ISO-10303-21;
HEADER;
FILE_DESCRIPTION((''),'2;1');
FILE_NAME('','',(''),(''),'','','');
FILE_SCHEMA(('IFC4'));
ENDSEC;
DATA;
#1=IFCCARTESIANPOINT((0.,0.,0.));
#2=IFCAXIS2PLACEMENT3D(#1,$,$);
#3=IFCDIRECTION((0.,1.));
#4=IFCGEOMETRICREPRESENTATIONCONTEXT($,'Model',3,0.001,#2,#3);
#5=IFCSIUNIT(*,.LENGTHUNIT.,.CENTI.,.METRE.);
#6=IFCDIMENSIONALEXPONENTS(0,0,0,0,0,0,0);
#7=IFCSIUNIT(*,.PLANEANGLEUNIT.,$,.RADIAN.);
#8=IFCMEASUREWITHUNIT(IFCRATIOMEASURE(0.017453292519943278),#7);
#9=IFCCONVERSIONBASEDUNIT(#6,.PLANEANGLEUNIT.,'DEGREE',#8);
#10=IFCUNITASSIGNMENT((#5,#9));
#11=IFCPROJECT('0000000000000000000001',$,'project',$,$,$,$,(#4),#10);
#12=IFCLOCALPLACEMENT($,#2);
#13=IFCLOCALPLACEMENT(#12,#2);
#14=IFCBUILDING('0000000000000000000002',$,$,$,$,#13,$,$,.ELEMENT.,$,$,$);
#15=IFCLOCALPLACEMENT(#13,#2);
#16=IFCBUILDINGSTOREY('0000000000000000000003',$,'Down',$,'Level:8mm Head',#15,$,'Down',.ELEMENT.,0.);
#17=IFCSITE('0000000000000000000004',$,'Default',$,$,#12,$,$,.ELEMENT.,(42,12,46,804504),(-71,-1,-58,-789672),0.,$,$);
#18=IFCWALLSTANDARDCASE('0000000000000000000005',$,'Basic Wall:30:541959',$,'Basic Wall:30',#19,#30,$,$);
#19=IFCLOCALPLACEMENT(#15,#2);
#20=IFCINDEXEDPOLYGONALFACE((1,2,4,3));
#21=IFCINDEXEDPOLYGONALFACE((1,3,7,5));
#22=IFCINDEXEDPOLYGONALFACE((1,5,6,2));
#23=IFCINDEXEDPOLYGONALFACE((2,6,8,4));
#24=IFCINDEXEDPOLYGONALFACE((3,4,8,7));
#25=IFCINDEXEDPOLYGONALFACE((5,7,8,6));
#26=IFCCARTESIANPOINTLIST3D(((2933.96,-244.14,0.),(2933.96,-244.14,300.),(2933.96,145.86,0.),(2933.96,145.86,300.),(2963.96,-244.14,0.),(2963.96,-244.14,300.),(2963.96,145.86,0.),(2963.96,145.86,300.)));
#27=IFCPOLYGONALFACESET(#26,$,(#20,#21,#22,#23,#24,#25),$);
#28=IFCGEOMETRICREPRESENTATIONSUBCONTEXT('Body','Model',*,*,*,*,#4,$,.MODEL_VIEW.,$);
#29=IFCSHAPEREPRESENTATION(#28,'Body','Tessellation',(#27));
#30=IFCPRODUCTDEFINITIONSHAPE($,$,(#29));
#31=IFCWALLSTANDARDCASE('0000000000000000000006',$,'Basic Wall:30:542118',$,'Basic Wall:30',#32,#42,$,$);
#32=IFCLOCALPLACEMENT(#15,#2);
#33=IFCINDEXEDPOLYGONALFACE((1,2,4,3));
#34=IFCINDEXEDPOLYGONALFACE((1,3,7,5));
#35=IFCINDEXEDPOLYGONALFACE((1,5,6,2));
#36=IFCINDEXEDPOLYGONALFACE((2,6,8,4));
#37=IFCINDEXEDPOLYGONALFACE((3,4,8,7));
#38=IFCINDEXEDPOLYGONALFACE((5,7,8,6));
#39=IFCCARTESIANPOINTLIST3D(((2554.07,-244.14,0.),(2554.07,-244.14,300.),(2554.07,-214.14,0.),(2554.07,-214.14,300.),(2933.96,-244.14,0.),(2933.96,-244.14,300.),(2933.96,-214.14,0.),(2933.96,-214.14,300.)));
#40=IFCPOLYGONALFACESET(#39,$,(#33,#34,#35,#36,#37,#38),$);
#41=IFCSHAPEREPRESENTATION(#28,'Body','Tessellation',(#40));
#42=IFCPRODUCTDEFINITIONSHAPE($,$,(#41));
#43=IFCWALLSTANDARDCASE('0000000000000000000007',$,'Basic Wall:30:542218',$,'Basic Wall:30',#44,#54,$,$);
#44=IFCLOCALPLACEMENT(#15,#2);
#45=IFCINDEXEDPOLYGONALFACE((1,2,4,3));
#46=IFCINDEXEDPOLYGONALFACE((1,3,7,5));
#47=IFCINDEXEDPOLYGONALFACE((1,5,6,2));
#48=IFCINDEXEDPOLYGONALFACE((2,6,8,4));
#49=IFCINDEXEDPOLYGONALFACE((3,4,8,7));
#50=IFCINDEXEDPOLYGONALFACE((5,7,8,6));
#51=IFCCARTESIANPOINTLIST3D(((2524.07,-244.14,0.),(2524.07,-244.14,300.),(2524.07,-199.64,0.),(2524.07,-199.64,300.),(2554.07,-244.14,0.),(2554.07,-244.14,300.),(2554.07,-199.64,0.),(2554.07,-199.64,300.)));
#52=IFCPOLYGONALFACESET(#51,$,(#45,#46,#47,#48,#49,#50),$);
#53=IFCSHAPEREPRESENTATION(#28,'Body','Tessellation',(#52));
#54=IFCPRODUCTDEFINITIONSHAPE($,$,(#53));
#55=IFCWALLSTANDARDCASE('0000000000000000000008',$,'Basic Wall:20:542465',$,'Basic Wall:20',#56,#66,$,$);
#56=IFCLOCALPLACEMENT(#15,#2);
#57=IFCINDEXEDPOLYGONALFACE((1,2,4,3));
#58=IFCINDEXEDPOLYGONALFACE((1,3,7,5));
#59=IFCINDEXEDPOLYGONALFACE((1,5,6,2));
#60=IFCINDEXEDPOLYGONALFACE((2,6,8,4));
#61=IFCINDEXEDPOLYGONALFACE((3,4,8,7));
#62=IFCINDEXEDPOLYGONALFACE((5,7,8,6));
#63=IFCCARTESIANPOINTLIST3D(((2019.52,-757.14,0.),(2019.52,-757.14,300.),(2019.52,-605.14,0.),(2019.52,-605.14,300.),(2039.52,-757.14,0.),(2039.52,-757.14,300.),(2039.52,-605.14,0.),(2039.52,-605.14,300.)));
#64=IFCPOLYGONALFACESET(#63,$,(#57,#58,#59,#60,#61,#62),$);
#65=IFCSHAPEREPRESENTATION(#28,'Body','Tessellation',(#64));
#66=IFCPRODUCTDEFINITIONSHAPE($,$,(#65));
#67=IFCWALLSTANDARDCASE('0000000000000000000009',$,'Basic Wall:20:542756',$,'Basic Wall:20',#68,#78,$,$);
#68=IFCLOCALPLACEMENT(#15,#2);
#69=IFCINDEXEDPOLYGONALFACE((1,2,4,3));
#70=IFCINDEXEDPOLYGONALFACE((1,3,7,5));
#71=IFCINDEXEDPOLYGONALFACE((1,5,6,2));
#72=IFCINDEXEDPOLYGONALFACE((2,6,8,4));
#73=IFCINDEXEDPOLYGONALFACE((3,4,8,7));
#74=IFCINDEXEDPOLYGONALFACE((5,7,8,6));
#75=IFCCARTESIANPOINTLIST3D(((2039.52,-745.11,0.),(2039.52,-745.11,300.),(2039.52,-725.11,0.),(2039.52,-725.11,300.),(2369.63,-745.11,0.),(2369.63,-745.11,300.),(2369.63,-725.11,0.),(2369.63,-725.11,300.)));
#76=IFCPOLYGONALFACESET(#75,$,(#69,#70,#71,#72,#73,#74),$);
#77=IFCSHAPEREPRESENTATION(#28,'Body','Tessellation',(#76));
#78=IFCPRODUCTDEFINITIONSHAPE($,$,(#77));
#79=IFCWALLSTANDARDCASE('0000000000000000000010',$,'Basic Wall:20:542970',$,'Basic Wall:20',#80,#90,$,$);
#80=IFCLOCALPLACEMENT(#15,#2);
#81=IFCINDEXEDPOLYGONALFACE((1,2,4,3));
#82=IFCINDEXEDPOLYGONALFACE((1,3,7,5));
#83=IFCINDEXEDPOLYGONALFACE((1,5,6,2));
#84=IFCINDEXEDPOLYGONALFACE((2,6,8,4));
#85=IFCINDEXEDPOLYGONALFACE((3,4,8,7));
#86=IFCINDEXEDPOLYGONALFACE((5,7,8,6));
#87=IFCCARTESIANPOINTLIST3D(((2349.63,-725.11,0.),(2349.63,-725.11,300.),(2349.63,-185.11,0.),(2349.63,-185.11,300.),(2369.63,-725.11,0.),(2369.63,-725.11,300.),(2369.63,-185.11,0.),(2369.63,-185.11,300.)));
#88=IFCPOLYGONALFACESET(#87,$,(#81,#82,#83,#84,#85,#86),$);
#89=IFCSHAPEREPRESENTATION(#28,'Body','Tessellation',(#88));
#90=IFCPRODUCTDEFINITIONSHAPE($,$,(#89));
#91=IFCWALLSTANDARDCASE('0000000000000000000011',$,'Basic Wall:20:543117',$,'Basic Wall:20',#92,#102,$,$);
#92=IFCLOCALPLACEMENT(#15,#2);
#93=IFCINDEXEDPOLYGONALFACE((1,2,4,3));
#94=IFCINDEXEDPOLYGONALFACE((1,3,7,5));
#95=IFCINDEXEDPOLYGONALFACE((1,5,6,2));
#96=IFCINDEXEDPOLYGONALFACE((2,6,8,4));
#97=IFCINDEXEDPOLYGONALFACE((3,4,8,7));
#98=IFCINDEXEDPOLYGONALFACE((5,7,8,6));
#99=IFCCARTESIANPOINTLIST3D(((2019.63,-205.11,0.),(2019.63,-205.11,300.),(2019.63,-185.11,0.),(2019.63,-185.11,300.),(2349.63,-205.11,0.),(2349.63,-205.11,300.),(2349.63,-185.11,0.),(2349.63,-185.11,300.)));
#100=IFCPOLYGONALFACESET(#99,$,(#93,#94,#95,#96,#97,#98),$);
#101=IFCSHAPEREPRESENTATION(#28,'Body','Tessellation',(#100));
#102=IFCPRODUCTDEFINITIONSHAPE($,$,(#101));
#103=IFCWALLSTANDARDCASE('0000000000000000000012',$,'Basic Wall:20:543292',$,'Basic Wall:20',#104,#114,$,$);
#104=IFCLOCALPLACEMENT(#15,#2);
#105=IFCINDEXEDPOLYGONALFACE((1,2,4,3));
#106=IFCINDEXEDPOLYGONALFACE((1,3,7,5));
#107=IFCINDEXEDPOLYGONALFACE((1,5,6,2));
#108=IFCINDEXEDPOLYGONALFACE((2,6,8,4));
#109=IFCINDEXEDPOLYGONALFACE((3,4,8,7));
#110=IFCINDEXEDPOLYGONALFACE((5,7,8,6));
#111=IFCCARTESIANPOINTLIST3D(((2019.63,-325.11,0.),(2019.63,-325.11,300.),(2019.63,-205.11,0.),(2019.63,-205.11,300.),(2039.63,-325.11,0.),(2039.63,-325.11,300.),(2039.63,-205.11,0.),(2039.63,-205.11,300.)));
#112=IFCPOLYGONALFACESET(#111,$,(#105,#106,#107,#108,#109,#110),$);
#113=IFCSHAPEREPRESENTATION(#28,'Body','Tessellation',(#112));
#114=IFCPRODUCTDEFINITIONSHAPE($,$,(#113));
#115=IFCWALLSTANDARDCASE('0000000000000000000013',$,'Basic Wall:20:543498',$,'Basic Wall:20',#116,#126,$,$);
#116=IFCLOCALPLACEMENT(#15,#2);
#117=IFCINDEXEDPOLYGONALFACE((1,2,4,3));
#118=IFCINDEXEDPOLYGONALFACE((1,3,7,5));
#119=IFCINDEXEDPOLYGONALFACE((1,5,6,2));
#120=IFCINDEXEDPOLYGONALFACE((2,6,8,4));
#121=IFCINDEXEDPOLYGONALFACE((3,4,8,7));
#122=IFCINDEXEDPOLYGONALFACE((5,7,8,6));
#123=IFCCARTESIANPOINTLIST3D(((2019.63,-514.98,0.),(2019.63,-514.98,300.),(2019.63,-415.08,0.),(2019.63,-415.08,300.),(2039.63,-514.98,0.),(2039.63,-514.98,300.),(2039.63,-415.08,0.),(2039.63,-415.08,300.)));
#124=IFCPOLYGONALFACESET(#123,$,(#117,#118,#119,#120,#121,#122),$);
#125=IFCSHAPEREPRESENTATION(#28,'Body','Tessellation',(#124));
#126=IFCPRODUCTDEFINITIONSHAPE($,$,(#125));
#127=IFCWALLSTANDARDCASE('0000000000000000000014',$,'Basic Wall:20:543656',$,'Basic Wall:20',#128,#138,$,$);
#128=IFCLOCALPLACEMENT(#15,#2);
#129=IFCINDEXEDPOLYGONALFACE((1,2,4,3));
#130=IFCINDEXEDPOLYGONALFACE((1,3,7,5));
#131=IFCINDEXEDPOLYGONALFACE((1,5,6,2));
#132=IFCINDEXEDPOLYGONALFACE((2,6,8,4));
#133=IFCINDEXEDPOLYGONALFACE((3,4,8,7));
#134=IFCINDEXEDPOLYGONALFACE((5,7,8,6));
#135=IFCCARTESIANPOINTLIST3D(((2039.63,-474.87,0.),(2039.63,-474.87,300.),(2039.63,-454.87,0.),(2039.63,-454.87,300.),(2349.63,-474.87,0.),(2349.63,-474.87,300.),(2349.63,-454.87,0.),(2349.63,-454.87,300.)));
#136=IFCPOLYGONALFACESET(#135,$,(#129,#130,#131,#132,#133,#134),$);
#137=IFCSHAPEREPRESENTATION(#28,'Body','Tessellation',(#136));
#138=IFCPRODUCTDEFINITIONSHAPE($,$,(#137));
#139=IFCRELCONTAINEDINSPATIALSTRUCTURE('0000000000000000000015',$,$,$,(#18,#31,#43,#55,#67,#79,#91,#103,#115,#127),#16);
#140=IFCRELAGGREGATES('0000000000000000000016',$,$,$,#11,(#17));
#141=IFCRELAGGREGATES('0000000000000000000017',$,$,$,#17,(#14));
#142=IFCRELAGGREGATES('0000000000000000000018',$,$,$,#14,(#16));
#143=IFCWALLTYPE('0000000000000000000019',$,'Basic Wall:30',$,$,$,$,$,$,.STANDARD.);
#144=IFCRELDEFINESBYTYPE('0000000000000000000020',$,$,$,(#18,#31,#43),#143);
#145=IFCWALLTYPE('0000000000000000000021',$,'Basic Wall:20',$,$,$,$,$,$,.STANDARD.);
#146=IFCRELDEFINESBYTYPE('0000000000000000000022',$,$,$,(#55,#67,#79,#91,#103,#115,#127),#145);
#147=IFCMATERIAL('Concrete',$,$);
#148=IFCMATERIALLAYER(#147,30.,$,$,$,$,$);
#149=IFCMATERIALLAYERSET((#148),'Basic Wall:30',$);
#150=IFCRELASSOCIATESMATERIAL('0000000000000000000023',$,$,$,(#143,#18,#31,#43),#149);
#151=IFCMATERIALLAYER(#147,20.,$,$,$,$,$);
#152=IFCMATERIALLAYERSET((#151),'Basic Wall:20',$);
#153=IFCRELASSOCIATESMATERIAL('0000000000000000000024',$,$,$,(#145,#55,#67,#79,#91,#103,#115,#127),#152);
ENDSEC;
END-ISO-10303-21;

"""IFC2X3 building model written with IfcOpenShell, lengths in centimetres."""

from ifc_helpers import new_model, entity, si_unit, converted_unit, direction, frame, frame_2d, origin, place, context, subcontext, project, spatial, rectangle, extrude, material, layer, layer_set, layer_usage, type_object, element, save


model = new_model("IFC2X3")

# Units and contexts
model_context = context("Model", 3, precision=0.001, world=origin(), true_north=direction((0.0, 1.0)))
body_context = subcontext(model_context, "Body", "Model", "MODEL_VIEW")
ifc_project = project(units=[si_unit("LENGTHUNIT", "METRE", prefix="CENTI"), converted_unit("PLANEANGLEUNIT", "DEGREE", entity("IfcRatioMeasure", 0.017453292519943278), si_unit("PLANEANGLEUNIT", "RADIAN"), dimensions=[0, 0, 0, 0, 0, 0, 0])], contexts=[model_context])

# Site, building, storey
site_placement = place(None, origin())
site = spatial("IfcSite", under=ifc_project, at=site_placement, Name="Default", CompositionType="ELEMENT", RefLatitude=(42, 12, 46, 804504), RefLongitude=(-71, -1, -58, -789672), RefElevation=0.0)
building_placement = place(site_placement, origin())
building = spatial("IfcBuilding", under=site, at=building_placement, CompositionType="ELEMENT")
storey_placement = place(building_placement, origin())
storey = spatial("IfcBuildingStorey", under=building, at=storey_placement, Name="Down", ObjectType="Level:8mm Head", LongName="Down", CompositionType="ELEMENT", Elevation=0.0)

# Shared definitions
ifc_material = material(Name="Concrete")

# Walls
ifc_layer_1 = layer(ifc_material, 30.0)
ifc_layer_set_1 = layer_set([ifc_layer_1], Name="Basic Wall:30")
wall_type_1 = type_object("IfcWallType", Name="Basic Wall:30", PredefinedType="STANDARD", material=ifc_layer_set_1)
ifc_layer_usage_1 = layer_usage(ifc_layer_set_1, "AXIS2", "NEGATIVE", 15.0)
wall_1_placement = place(storey_placement, frame((2948.96, 145.86, 0.0), z_axis=(0.0, 0.0, 1.0), x_axis=(0.0, -1.0, 0.0)))
element("IfcWallStandardCase", 1, at=wall_1_placement, inside=storey, type_object=wall_type_1, material=ifc_layer_usage_1, Name="Basic Wall:30:541959", ObjectType="Basic Wall:30", context=body_context, shape_type="SweptSolid", body=[
    extrude(rectangle(XDim=390.0, YDim=30.0, at=frame_2d((195.0, 0.0), x_axis=(-1.0, 0.0))), origin(), (0.0, 0.0, 1.0), 300.0),
])
ifc_layer_usage_2 = layer_usage(ifc_layer_set_1, "AXIS2", "NEGATIVE", 15.0)
wall_2_placement = place(storey_placement, frame((2933.96, -229.14, 0.0), z_axis=(0.0, 0.0, 1.0), x_axis=(-1.0, 0.0, 0.0)))
element("IfcWallStandardCase", 2, at=wall_2_placement, inside=storey, type_object=wall_type_1, material=ifc_layer_usage_2, Name="Basic Wall:30:542118", ObjectType="Basic Wall:30", context=body_context, shape_type="SweptSolid", body=[
    extrude(rectangle(XDim=379.89, YDim=30.0, at=frame_2d((189.95, 0.0), x_axis=(-1.0, 0.0))), origin(), (0.0, 0.0, 1.0), 300.0),
])
ifc_layer_usage_3 = layer_usage(ifc_layer_set_1, "AXIS2", "NEGATIVE", 15.0)
wall_3_placement = place(storey_placement, frame((2539.07, -244.14, 0.0), z_axis=(0.0, 0.0, 1.0), x_axis=(0.0, 1.0, 0.0)))
element("IfcWallStandardCase", 3, at=wall_3_placement, inside=storey, type_object=wall_type_1, material=ifc_layer_usage_3, Name="Basic Wall:30:542218", ObjectType="Basic Wall:30", context=body_context, shape_type="SweptSolid", body=[
    extrude(rectangle(XDim=44.5, YDim=30.0, at=frame_2d((22.25, 0.0), x_axis=(-1.0, 0.0))), origin(), (0.0, 0.0, 1.0), 300.0),
])
ifc_layer_2 = layer(ifc_material, 20.0)
ifc_layer_set_2 = layer_set([ifc_layer_2], Name="Basic Wall:20")
ifc_layer_usage_4 = layer_usage(ifc_layer_set_2, "AXIS2", "POSITIVE", -10.0)
wall_type_2 = type_object("IfcWallType", Name="Basic Wall:20", PredefinedType="STANDARD", material=ifc_layer_set_2)
wall_4_placement = place(storey_placement, frame((2029.52, -605.14, 0.0), z_axis=(0.0, 0.0, 1.0), x_axis=(0.0, -1.0, 0.0)))
element("IfcWallStandardCase", 4, at=wall_4_placement, inside=storey, type_object=wall_type_2, material=ifc_layer_usage_4, Name="Basic Wall:20:542465", ObjectType="Basic Wall:20", context=body_context, shape_type="SweptSolid", body=[
    extrude(rectangle(XDim=152.0, YDim=20.0, at=frame_2d((76.0, 0.0), x_axis=(-1.0, 0.0))), origin(), (0.0, 0.0, 1.0), 300.0),
])
ifc_layer_usage_5 = layer_usage(ifc_layer_set_2, "AXIS2", "POSITIVE", -10.0)
wall_5_placement = place(storey_placement, frame((2039.52, -735.11, 0.0)))
element("IfcWallStandardCase", 5, at=wall_5_placement, inside=storey, type_object=wall_type_2, material=ifc_layer_usage_5, Name="Basic Wall:20:542756", ObjectType="Basic Wall:20", context=body_context, shape_type="SweptSolid", body=[
    extrude(rectangle(XDim=330.11, YDim=20.0, at=frame_2d((165.06, 0.0), x_axis=(-1.0, 0.0))), origin(), (0.0, 0.0, 1.0), 300.0),
])
ifc_layer_usage_6 = layer_usage(ifc_layer_set_2, "AXIS2", "POSITIVE", -10.0)
wall_6_placement = place(storey_placement, frame((2359.63, -725.11, 0.0), z_axis=(0.0, 0.0, 1.0), x_axis=(0.0, 1.0, 0.0)))
element("IfcWallStandardCase", 6, at=wall_6_placement, inside=storey, type_object=wall_type_2, material=ifc_layer_usage_6, Name="Basic Wall:20:542970", ObjectType="Basic Wall:20", context=body_context, shape_type="SweptSolid", body=[
    extrude(rectangle(XDim=540.0, YDim=20.0, at=frame_2d((270.0, 0.0), x_axis=(-1.0, 0.0))), origin(), (0.0, 0.0, 1.0), 300.0),
])
ifc_layer_usage_7 = layer_usage(ifc_layer_set_2, "AXIS2", "POSITIVE", -10.0)
wall_7_placement = place(storey_placement, frame((2349.63, -195.11, 0.0), z_axis=(0.0, 0.0, 1.0), x_axis=(-1.0, 0.0, 0.0)))
element("IfcWallStandardCase", 7, at=wall_7_placement, inside=storey, type_object=wall_type_2, material=ifc_layer_usage_7, Name="Basic Wall:20:543117", ObjectType="Basic Wall:20", context=body_context, shape_type="SweptSolid", body=[
    extrude(rectangle(XDim=330.0, YDim=20.0, at=frame_2d((165.0, 0.0), x_axis=(-1.0, 0.0))), origin(), (0.0, 0.0, 1.0), 300.0),
])
ifc_layer_usage_8 = layer_usage(ifc_layer_set_2, "AXIS2", "POSITIVE", -10.0)
wall_8_placement = place(storey_placement, frame((2029.63, -205.11, 0.0), z_axis=(0.0, 0.0, 1.0), x_axis=(0.0, -1.0, 0.0)))
element("IfcWallStandardCase", 8, at=wall_8_placement, inside=storey, type_object=wall_type_2, material=ifc_layer_usage_8, Name="Basic Wall:20:543292", ObjectType="Basic Wall:20", context=body_context, shape_type="SweptSolid", body=[
    extrude(rectangle(XDim=120.0, YDim=20.0, at=frame_2d((60.0, 0.0), x_axis=(-1.0, 0.0))), origin(), (0.0, 0.0, 1.0), 300.0),
])
ifc_layer_usage_9 = layer_usage(ifc_layer_set_2, "AXIS2", "POSITIVE", -10.0)
wall_9_placement = place(storey_placement, frame((2029.63, -415.08, 0.0), z_axis=(0.0, 0.0, 1.0), x_axis=(0.0, -1.0, 0.0)))
element("IfcWallStandardCase", 9, at=wall_9_placement, inside=storey, type_object=wall_type_2, material=ifc_layer_usage_9, Name="Basic Wall:20:543498", ObjectType="Basic Wall:20", context=body_context, shape_type="SweptSolid", body=[
    extrude(rectangle(XDim=99.9, YDim=20.0, at=frame_2d((49.95, 0.0), x_axis=(-1.0, 0.0))), origin(), (0.0, 0.0, 1.0), 300.0),
])
ifc_layer_usage_10 = layer_usage(ifc_layer_set_2, "AXIS2", "NEGATIVE", 10.0)
wall_10_placement = place(storey_placement, frame((2039.63, -464.87, 0.0)))
element("IfcWallStandardCase", 10, at=wall_10_placement, inside=storey, type_object=wall_type_2, material=ifc_layer_usage_10, Name="Basic Wall:20:543656", ObjectType="Basic Wall:20", context=body_context, shape_type="SweptSolid", body=[
    extrude(rectangle(XDim=310.0, YDim=20.0, at=frame_2d((155.0, 0.0), x_axis=(-1.0, 0.0))), origin(), (0.0, 0.0, 1.0), 300.0),
])

save(model, "model.ifc")
